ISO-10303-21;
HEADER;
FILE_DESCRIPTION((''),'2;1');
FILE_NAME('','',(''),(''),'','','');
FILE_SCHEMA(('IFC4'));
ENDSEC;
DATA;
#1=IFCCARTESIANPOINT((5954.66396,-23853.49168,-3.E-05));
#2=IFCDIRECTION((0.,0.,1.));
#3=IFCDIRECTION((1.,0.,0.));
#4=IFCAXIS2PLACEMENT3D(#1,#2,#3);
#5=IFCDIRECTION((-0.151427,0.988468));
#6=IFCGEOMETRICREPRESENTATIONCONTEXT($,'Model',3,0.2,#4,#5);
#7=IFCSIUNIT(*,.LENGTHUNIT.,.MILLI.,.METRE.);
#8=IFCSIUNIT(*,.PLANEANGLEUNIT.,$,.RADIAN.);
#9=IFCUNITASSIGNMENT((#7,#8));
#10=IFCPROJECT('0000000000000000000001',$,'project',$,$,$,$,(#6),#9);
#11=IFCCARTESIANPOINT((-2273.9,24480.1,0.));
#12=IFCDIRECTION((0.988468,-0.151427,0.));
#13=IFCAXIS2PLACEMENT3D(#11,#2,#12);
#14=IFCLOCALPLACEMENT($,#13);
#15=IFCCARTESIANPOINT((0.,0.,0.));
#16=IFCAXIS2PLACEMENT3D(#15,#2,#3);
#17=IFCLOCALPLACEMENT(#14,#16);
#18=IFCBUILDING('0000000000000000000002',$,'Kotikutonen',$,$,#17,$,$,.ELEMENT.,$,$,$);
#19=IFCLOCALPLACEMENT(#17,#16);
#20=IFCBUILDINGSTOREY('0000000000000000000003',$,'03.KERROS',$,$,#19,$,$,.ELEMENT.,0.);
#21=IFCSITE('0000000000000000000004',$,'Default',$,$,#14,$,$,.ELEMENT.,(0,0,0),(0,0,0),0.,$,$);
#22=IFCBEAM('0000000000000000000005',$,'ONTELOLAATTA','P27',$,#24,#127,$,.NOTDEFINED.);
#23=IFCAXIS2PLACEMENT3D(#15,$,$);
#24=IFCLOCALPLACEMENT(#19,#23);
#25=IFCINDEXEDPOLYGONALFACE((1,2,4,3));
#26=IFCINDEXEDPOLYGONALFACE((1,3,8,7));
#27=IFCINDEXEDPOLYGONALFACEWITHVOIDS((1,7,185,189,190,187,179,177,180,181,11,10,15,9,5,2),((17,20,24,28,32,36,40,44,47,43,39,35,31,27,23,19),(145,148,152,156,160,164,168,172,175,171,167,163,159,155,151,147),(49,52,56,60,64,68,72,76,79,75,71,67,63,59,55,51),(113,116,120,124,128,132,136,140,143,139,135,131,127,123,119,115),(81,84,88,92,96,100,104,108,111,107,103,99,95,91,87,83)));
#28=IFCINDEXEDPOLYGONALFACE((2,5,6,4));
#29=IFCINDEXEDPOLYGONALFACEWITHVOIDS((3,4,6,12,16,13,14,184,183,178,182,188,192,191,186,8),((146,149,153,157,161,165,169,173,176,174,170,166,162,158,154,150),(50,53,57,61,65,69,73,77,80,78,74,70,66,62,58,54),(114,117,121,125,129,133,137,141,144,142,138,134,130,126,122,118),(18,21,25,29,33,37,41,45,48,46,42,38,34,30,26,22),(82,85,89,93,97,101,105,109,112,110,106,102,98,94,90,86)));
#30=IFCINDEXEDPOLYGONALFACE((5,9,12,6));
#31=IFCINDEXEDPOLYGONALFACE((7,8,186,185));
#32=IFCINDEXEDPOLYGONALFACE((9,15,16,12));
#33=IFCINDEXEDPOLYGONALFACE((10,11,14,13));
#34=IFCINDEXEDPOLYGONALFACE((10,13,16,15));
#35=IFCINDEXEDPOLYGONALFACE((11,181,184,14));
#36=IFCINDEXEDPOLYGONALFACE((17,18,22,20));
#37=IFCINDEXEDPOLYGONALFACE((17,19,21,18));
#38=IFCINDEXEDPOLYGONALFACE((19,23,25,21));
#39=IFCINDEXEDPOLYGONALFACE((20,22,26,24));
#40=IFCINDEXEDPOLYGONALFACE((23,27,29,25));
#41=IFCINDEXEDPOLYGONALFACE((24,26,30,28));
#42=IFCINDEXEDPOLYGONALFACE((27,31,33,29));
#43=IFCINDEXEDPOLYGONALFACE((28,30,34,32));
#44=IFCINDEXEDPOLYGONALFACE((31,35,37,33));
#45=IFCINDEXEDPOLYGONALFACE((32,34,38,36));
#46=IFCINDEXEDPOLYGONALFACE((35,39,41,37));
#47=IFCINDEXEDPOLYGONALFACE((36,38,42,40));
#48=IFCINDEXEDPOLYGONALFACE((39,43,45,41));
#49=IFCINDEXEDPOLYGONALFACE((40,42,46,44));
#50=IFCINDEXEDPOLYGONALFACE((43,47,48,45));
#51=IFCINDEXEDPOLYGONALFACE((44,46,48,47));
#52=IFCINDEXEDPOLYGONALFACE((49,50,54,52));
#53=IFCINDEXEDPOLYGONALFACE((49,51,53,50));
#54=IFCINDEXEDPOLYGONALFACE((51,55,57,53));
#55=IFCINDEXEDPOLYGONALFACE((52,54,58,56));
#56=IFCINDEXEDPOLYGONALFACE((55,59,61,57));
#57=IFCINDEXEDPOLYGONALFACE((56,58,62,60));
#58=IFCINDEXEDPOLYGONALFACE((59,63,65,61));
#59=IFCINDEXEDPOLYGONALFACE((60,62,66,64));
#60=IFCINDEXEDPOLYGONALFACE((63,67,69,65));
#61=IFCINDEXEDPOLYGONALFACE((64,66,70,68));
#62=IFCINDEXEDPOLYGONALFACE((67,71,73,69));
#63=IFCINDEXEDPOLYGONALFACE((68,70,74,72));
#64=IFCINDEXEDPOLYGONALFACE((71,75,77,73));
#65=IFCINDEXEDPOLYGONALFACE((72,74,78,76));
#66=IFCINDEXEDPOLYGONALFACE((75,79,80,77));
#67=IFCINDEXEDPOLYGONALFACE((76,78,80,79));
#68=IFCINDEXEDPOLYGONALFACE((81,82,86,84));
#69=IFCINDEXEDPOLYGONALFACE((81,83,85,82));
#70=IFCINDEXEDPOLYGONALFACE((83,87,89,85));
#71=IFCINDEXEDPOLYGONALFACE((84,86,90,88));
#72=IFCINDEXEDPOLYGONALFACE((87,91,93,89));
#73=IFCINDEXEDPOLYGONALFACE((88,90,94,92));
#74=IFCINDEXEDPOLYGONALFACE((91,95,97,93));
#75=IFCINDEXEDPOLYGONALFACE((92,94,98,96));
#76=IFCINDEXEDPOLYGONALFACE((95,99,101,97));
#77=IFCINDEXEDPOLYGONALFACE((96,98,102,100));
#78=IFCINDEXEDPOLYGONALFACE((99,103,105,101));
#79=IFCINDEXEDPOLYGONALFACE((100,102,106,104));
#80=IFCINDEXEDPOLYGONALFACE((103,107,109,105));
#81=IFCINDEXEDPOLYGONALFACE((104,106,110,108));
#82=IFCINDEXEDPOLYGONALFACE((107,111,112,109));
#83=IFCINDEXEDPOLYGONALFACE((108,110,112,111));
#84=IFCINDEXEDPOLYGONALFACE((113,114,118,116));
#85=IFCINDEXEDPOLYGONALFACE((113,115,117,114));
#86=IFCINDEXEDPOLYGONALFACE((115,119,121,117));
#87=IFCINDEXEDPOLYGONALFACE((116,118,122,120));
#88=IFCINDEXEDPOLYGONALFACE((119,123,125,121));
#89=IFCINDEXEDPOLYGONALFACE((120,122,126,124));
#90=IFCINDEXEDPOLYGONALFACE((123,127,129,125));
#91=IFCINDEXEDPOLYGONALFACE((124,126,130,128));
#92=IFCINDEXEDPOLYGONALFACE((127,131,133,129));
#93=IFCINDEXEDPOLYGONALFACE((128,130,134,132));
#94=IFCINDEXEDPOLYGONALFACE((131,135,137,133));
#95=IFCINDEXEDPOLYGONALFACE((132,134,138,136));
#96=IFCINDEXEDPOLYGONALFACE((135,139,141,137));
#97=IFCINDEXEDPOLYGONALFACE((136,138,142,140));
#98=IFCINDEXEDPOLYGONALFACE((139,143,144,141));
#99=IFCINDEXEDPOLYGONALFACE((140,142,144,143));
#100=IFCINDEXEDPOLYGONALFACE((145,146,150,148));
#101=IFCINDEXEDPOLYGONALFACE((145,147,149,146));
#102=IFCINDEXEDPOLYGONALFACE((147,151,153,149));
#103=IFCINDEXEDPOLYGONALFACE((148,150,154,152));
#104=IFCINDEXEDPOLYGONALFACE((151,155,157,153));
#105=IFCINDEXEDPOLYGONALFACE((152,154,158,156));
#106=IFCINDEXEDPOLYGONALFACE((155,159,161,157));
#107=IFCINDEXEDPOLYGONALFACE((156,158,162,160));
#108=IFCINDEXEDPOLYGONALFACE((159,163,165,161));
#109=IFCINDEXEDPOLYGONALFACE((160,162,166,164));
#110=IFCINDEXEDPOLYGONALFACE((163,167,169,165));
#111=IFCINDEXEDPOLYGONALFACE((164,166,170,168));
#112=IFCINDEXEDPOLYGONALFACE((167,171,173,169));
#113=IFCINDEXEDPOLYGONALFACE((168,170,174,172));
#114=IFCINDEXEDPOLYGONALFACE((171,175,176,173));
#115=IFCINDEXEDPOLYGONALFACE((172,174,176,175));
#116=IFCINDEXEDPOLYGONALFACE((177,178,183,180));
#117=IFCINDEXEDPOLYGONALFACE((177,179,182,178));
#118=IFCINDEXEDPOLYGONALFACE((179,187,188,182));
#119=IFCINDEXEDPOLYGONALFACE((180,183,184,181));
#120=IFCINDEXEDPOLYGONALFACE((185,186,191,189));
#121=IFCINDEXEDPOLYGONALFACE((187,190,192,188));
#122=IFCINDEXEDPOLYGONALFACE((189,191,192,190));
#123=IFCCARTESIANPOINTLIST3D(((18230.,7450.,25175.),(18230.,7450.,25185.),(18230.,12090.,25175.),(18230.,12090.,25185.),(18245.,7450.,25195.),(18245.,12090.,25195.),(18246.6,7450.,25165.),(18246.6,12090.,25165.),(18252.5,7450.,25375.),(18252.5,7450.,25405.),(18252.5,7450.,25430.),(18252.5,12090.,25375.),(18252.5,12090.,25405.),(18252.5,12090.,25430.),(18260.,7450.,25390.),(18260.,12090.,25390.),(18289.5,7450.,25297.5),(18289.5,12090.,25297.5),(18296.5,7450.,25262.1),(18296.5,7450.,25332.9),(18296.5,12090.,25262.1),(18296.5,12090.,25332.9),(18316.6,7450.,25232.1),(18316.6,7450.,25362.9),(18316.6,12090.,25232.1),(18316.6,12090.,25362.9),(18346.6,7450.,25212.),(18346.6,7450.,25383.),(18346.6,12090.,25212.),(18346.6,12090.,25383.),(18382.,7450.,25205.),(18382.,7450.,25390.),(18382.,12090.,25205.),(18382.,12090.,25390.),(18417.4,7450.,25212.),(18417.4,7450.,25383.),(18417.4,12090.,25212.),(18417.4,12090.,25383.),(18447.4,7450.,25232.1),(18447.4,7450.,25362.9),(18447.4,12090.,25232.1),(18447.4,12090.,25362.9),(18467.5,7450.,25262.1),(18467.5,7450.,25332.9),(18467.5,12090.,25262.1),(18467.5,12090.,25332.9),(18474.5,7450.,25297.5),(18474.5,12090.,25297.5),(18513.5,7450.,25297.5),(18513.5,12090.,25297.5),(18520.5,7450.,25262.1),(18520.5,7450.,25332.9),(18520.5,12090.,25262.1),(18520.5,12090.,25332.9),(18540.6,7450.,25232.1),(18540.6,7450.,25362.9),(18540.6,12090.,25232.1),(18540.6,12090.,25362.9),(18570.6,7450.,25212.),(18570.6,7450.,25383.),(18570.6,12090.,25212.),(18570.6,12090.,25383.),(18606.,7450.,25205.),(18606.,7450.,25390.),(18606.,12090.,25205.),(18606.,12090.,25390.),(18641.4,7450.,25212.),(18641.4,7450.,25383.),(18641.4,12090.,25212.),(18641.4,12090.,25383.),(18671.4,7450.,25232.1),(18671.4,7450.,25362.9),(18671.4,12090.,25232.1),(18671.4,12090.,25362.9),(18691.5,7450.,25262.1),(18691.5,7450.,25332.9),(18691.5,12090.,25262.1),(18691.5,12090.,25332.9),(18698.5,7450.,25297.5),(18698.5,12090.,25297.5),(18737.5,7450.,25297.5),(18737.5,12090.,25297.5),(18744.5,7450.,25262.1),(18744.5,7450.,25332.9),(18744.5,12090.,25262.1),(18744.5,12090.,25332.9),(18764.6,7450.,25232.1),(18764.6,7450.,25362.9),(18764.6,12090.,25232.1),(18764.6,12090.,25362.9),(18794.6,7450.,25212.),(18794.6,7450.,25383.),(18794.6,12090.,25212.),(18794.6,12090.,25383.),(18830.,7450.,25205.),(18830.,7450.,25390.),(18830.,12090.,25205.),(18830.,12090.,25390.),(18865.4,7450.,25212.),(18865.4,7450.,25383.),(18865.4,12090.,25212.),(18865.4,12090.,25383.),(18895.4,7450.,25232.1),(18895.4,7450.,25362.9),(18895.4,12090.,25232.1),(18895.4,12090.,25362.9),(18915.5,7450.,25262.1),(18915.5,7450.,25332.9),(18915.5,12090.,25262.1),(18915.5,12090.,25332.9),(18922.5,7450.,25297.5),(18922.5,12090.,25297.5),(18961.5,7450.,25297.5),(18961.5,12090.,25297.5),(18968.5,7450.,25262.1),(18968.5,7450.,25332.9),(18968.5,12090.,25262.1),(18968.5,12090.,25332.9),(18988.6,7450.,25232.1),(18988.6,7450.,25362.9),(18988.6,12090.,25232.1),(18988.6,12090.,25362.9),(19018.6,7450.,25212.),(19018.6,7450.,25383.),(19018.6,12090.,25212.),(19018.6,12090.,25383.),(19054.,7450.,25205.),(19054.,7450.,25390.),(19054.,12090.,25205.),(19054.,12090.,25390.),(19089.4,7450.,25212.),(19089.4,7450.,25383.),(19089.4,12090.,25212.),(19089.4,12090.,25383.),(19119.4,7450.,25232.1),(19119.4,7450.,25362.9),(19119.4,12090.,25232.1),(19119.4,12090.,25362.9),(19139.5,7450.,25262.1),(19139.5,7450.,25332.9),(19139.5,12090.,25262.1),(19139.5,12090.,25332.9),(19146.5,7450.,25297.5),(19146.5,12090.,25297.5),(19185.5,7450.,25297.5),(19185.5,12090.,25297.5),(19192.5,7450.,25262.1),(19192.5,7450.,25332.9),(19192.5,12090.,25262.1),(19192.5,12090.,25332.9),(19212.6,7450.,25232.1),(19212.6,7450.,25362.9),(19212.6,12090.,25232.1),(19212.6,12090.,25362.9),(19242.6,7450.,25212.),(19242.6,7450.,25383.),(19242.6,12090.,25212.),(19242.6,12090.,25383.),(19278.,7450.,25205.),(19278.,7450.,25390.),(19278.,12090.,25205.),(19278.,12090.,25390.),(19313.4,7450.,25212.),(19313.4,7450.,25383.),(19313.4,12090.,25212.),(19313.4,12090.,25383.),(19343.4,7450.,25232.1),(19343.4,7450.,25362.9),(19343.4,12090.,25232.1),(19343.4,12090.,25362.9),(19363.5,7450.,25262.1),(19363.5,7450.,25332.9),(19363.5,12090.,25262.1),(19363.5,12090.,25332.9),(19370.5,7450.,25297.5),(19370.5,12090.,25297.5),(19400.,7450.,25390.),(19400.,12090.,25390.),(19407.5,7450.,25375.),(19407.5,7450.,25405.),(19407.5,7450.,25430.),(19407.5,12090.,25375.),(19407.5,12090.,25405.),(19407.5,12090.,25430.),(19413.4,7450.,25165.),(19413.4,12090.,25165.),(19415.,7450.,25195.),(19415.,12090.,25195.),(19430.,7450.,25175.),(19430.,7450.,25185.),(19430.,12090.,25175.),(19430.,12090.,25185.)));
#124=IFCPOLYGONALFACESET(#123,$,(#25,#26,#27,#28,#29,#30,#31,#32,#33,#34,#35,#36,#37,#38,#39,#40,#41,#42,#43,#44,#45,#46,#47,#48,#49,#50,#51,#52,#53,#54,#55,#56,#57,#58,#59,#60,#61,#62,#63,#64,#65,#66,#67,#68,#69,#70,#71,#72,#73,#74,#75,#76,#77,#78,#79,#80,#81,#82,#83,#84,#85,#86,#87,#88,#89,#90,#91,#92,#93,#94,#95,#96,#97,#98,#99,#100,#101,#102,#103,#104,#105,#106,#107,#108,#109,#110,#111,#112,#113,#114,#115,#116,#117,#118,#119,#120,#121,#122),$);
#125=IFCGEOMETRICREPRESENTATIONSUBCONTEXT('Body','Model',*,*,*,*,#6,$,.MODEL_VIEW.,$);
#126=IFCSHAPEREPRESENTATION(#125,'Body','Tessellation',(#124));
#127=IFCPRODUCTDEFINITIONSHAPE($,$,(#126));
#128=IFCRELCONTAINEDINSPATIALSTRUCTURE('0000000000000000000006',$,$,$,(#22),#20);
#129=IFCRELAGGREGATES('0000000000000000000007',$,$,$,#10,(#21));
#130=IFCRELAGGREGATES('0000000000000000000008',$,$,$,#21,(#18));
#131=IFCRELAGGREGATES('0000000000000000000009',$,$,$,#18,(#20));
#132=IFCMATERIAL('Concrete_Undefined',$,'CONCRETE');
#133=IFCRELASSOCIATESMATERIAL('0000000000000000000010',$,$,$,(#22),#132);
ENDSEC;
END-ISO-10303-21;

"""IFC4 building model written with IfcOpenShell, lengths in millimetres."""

from ifc_helpers import new_model, si_unit, direction, frame, origin_with_axes, place, context, subcontext, project, spatial, line, indexed_curve, outline, extrude, material, element, save


model = new_model("IFC4")

# Units and contexts
model_context = context("Model", 3, precision=0.2, world=frame((5954.66396, -23853.49168, -3e-05), z_axis=(0.0, 0.0, 1.0), x_axis=(1.0, 0.0, 0.0)), true_north=direction((-0.151427, 0.988468)))
body_context = subcontext(model_context, "Body", "Model", "MODEL_VIEW")
ifc_project = project(units=[si_unit("LENGTHUNIT", "METRE", prefix="MILLI"), si_unit("PLANEANGLEUNIT", "RADIAN")], contexts=[model_context])

# Site, building, storey
site_placement = place(None, frame((-2273.9, 24480.1, 0.0), z_axis=(0.0, 0.0, 1.0), x_axis=(0.988468, -0.151427, 0.0)))
site = spatial("IfcSite", under=ifc_project, at=site_placement, Name="Default", CompositionType="ELEMENT", RefLatitude=(0, 0, 0), RefLongitude=(0, 0, 0), RefElevation=0.0)
building_placement = place(site_placement, origin_with_axes())
building = spatial("IfcBuilding", under=site, at=building_placement, Name="Kotikutonen", CompositionType="ELEMENT")
storey_placement = place(building_placement, origin_with_axes())
storey = spatial("IfcBuildingStorey", under=building, at=storey_placement, Name="03.KERROS", CompositionType="ELEMENT", Elevation=0.0)

# Shared definitions
ifc_material_1 = material(Name="Concrete_Undefined", Category="CONCRETE")

# Beam
beam_1_placement = place(storey_placement, frame((18830.0, 12090.0, 25297.5), z_axis=(-1.0, 0.0, 0.0), x_axis=(0.0, -1.0, 0.0)))
element("IfcBeam", 1, at=beam_1_placement, inside=storey, material=ifc_material_1, Name="ONTELOLAATTA", Description="P27", PredefinedType="NOTDEFINED", context=body_context, shape_type="SolidModel", body=[
    extrude(outline(indexed_curve([(-600.0, -122.5), (-583.4, -132.5), (583.4, -132.5), (600.0, -122.5), (600.0, -112.5), (585.0, -102.5), (577.5, 77.5), (570.0, 92.5), (577.5, 107.5), (577.5, 132.5), (-577.5, 132.5), (-577.5, 107.5), (-570.0, 92.5), (-577.5, 77.5), (-585.0, -102.5), (-600.0, -112.5)], segments=[line(1, 2, 3, 4, 5, 6, 7, 8, 9, 10, 11, 12, 13, 14, 15, 16, 1)]), holes=[indexed_curve([(-448.0, -92.5), (-483.4, -85.5), (-513.4, -65.4), (-533.5, -35.4), (-540.5, 0.0), (-533.5, 35.4), (-513.4, 65.4), (-483.4, 85.5), (-448.0, 92.5), (-412.6, 85.5), (-382.6, 65.4), (-362.5, 35.4), (-355.5, 0.0), (-362.5, -35.4), (-382.6, -65.4), (-412.6, -85.5)], segments=[line(1, 2, 3, 4, 5, 6, 7, 8, 9, 10, 11, 12, 13, 14, 15, 16, 1)]), indexed_curve([(-224.0, -92.5), (-259.4, -85.5), (-289.4, -65.4), (-309.5, -35.4), (-316.5, 0.0), (-309.5, 35.4), (-289.4, 65.4), (-259.4, 85.5), (-224.0, 92.5), (-188.6, 85.5), (-158.6, 65.4), (-138.5, 35.4), (-131.5, 0.0), (-138.5, -35.4), (-158.6, -65.4), (-188.6, -85.5)], segments=[line(1, 2, 3, 4, 5, 6, 7, 8, 9, 10, 11, 12, 13, 14, 15, 16, 1)]), indexed_curve([(0.0, -92.5), (-35.4, -85.5), (-65.4, -65.4), (-85.5, -35.4), (-92.5, 0.0), (-85.5, 35.4), (-65.4, 65.4), (-35.4, 85.5), (0.0, 92.5), (35.4, 85.5), (65.4, 65.4), (85.5, 35.4), (92.5, 0.0), (85.5, -35.4), (65.4, -65.4), (35.4, -85.5)], segments=[line(1, 2, 3, 4, 5, 6, 7, 8, 9, 10, 11, 12, 13, 14, 15, 16, 1)]), indexed_curve([(224.0, -92.5), (188.6, -85.5), (158.6, -65.4), (138.5, -35.4), (131.5, 0.0), (138.5, 35.4), (158.6, 65.4), (188.6, 85.5), (224.0, 92.5), (259.4, 85.5), (289.4, 65.4), (309.5, 35.4), (316.5, 0.0), (309.5, -35.4), (289.4, -65.4), (259.4, -85.5)], segments=[line(1, 2, 3, 4, 5, 6, 7, 8, 9, 10, 11, 12, 13, 14, 15, 16, 1)]), indexed_curve([(448.0, -92.5), (412.6, -85.5), (382.6, -65.4), (362.5, -35.4), (355.5, 0.0), (362.5, 35.4), (382.6, 65.4), (412.6, 85.5), (448.0, 92.5), (483.4, 85.5), (513.4, 65.4), (533.5, 35.4), (540.5, 0.0), (533.5, -35.4), (513.4, -65.4), (483.4, -85.5)], segments=[line(1, 2, 3, 4, 5, 6, 7, 8, 9, 10, 11, 12, 13, 14, 15, 16, 1)])]), frame((0.0, 0.0, 0.0), z_axis=(-1.0, 0.0, 0.0), x_axis=(0.0, 0.0, 1.0)), (0.0, 0.0, -1.0), 4640.0),
])

save(model, "model.ifc")
